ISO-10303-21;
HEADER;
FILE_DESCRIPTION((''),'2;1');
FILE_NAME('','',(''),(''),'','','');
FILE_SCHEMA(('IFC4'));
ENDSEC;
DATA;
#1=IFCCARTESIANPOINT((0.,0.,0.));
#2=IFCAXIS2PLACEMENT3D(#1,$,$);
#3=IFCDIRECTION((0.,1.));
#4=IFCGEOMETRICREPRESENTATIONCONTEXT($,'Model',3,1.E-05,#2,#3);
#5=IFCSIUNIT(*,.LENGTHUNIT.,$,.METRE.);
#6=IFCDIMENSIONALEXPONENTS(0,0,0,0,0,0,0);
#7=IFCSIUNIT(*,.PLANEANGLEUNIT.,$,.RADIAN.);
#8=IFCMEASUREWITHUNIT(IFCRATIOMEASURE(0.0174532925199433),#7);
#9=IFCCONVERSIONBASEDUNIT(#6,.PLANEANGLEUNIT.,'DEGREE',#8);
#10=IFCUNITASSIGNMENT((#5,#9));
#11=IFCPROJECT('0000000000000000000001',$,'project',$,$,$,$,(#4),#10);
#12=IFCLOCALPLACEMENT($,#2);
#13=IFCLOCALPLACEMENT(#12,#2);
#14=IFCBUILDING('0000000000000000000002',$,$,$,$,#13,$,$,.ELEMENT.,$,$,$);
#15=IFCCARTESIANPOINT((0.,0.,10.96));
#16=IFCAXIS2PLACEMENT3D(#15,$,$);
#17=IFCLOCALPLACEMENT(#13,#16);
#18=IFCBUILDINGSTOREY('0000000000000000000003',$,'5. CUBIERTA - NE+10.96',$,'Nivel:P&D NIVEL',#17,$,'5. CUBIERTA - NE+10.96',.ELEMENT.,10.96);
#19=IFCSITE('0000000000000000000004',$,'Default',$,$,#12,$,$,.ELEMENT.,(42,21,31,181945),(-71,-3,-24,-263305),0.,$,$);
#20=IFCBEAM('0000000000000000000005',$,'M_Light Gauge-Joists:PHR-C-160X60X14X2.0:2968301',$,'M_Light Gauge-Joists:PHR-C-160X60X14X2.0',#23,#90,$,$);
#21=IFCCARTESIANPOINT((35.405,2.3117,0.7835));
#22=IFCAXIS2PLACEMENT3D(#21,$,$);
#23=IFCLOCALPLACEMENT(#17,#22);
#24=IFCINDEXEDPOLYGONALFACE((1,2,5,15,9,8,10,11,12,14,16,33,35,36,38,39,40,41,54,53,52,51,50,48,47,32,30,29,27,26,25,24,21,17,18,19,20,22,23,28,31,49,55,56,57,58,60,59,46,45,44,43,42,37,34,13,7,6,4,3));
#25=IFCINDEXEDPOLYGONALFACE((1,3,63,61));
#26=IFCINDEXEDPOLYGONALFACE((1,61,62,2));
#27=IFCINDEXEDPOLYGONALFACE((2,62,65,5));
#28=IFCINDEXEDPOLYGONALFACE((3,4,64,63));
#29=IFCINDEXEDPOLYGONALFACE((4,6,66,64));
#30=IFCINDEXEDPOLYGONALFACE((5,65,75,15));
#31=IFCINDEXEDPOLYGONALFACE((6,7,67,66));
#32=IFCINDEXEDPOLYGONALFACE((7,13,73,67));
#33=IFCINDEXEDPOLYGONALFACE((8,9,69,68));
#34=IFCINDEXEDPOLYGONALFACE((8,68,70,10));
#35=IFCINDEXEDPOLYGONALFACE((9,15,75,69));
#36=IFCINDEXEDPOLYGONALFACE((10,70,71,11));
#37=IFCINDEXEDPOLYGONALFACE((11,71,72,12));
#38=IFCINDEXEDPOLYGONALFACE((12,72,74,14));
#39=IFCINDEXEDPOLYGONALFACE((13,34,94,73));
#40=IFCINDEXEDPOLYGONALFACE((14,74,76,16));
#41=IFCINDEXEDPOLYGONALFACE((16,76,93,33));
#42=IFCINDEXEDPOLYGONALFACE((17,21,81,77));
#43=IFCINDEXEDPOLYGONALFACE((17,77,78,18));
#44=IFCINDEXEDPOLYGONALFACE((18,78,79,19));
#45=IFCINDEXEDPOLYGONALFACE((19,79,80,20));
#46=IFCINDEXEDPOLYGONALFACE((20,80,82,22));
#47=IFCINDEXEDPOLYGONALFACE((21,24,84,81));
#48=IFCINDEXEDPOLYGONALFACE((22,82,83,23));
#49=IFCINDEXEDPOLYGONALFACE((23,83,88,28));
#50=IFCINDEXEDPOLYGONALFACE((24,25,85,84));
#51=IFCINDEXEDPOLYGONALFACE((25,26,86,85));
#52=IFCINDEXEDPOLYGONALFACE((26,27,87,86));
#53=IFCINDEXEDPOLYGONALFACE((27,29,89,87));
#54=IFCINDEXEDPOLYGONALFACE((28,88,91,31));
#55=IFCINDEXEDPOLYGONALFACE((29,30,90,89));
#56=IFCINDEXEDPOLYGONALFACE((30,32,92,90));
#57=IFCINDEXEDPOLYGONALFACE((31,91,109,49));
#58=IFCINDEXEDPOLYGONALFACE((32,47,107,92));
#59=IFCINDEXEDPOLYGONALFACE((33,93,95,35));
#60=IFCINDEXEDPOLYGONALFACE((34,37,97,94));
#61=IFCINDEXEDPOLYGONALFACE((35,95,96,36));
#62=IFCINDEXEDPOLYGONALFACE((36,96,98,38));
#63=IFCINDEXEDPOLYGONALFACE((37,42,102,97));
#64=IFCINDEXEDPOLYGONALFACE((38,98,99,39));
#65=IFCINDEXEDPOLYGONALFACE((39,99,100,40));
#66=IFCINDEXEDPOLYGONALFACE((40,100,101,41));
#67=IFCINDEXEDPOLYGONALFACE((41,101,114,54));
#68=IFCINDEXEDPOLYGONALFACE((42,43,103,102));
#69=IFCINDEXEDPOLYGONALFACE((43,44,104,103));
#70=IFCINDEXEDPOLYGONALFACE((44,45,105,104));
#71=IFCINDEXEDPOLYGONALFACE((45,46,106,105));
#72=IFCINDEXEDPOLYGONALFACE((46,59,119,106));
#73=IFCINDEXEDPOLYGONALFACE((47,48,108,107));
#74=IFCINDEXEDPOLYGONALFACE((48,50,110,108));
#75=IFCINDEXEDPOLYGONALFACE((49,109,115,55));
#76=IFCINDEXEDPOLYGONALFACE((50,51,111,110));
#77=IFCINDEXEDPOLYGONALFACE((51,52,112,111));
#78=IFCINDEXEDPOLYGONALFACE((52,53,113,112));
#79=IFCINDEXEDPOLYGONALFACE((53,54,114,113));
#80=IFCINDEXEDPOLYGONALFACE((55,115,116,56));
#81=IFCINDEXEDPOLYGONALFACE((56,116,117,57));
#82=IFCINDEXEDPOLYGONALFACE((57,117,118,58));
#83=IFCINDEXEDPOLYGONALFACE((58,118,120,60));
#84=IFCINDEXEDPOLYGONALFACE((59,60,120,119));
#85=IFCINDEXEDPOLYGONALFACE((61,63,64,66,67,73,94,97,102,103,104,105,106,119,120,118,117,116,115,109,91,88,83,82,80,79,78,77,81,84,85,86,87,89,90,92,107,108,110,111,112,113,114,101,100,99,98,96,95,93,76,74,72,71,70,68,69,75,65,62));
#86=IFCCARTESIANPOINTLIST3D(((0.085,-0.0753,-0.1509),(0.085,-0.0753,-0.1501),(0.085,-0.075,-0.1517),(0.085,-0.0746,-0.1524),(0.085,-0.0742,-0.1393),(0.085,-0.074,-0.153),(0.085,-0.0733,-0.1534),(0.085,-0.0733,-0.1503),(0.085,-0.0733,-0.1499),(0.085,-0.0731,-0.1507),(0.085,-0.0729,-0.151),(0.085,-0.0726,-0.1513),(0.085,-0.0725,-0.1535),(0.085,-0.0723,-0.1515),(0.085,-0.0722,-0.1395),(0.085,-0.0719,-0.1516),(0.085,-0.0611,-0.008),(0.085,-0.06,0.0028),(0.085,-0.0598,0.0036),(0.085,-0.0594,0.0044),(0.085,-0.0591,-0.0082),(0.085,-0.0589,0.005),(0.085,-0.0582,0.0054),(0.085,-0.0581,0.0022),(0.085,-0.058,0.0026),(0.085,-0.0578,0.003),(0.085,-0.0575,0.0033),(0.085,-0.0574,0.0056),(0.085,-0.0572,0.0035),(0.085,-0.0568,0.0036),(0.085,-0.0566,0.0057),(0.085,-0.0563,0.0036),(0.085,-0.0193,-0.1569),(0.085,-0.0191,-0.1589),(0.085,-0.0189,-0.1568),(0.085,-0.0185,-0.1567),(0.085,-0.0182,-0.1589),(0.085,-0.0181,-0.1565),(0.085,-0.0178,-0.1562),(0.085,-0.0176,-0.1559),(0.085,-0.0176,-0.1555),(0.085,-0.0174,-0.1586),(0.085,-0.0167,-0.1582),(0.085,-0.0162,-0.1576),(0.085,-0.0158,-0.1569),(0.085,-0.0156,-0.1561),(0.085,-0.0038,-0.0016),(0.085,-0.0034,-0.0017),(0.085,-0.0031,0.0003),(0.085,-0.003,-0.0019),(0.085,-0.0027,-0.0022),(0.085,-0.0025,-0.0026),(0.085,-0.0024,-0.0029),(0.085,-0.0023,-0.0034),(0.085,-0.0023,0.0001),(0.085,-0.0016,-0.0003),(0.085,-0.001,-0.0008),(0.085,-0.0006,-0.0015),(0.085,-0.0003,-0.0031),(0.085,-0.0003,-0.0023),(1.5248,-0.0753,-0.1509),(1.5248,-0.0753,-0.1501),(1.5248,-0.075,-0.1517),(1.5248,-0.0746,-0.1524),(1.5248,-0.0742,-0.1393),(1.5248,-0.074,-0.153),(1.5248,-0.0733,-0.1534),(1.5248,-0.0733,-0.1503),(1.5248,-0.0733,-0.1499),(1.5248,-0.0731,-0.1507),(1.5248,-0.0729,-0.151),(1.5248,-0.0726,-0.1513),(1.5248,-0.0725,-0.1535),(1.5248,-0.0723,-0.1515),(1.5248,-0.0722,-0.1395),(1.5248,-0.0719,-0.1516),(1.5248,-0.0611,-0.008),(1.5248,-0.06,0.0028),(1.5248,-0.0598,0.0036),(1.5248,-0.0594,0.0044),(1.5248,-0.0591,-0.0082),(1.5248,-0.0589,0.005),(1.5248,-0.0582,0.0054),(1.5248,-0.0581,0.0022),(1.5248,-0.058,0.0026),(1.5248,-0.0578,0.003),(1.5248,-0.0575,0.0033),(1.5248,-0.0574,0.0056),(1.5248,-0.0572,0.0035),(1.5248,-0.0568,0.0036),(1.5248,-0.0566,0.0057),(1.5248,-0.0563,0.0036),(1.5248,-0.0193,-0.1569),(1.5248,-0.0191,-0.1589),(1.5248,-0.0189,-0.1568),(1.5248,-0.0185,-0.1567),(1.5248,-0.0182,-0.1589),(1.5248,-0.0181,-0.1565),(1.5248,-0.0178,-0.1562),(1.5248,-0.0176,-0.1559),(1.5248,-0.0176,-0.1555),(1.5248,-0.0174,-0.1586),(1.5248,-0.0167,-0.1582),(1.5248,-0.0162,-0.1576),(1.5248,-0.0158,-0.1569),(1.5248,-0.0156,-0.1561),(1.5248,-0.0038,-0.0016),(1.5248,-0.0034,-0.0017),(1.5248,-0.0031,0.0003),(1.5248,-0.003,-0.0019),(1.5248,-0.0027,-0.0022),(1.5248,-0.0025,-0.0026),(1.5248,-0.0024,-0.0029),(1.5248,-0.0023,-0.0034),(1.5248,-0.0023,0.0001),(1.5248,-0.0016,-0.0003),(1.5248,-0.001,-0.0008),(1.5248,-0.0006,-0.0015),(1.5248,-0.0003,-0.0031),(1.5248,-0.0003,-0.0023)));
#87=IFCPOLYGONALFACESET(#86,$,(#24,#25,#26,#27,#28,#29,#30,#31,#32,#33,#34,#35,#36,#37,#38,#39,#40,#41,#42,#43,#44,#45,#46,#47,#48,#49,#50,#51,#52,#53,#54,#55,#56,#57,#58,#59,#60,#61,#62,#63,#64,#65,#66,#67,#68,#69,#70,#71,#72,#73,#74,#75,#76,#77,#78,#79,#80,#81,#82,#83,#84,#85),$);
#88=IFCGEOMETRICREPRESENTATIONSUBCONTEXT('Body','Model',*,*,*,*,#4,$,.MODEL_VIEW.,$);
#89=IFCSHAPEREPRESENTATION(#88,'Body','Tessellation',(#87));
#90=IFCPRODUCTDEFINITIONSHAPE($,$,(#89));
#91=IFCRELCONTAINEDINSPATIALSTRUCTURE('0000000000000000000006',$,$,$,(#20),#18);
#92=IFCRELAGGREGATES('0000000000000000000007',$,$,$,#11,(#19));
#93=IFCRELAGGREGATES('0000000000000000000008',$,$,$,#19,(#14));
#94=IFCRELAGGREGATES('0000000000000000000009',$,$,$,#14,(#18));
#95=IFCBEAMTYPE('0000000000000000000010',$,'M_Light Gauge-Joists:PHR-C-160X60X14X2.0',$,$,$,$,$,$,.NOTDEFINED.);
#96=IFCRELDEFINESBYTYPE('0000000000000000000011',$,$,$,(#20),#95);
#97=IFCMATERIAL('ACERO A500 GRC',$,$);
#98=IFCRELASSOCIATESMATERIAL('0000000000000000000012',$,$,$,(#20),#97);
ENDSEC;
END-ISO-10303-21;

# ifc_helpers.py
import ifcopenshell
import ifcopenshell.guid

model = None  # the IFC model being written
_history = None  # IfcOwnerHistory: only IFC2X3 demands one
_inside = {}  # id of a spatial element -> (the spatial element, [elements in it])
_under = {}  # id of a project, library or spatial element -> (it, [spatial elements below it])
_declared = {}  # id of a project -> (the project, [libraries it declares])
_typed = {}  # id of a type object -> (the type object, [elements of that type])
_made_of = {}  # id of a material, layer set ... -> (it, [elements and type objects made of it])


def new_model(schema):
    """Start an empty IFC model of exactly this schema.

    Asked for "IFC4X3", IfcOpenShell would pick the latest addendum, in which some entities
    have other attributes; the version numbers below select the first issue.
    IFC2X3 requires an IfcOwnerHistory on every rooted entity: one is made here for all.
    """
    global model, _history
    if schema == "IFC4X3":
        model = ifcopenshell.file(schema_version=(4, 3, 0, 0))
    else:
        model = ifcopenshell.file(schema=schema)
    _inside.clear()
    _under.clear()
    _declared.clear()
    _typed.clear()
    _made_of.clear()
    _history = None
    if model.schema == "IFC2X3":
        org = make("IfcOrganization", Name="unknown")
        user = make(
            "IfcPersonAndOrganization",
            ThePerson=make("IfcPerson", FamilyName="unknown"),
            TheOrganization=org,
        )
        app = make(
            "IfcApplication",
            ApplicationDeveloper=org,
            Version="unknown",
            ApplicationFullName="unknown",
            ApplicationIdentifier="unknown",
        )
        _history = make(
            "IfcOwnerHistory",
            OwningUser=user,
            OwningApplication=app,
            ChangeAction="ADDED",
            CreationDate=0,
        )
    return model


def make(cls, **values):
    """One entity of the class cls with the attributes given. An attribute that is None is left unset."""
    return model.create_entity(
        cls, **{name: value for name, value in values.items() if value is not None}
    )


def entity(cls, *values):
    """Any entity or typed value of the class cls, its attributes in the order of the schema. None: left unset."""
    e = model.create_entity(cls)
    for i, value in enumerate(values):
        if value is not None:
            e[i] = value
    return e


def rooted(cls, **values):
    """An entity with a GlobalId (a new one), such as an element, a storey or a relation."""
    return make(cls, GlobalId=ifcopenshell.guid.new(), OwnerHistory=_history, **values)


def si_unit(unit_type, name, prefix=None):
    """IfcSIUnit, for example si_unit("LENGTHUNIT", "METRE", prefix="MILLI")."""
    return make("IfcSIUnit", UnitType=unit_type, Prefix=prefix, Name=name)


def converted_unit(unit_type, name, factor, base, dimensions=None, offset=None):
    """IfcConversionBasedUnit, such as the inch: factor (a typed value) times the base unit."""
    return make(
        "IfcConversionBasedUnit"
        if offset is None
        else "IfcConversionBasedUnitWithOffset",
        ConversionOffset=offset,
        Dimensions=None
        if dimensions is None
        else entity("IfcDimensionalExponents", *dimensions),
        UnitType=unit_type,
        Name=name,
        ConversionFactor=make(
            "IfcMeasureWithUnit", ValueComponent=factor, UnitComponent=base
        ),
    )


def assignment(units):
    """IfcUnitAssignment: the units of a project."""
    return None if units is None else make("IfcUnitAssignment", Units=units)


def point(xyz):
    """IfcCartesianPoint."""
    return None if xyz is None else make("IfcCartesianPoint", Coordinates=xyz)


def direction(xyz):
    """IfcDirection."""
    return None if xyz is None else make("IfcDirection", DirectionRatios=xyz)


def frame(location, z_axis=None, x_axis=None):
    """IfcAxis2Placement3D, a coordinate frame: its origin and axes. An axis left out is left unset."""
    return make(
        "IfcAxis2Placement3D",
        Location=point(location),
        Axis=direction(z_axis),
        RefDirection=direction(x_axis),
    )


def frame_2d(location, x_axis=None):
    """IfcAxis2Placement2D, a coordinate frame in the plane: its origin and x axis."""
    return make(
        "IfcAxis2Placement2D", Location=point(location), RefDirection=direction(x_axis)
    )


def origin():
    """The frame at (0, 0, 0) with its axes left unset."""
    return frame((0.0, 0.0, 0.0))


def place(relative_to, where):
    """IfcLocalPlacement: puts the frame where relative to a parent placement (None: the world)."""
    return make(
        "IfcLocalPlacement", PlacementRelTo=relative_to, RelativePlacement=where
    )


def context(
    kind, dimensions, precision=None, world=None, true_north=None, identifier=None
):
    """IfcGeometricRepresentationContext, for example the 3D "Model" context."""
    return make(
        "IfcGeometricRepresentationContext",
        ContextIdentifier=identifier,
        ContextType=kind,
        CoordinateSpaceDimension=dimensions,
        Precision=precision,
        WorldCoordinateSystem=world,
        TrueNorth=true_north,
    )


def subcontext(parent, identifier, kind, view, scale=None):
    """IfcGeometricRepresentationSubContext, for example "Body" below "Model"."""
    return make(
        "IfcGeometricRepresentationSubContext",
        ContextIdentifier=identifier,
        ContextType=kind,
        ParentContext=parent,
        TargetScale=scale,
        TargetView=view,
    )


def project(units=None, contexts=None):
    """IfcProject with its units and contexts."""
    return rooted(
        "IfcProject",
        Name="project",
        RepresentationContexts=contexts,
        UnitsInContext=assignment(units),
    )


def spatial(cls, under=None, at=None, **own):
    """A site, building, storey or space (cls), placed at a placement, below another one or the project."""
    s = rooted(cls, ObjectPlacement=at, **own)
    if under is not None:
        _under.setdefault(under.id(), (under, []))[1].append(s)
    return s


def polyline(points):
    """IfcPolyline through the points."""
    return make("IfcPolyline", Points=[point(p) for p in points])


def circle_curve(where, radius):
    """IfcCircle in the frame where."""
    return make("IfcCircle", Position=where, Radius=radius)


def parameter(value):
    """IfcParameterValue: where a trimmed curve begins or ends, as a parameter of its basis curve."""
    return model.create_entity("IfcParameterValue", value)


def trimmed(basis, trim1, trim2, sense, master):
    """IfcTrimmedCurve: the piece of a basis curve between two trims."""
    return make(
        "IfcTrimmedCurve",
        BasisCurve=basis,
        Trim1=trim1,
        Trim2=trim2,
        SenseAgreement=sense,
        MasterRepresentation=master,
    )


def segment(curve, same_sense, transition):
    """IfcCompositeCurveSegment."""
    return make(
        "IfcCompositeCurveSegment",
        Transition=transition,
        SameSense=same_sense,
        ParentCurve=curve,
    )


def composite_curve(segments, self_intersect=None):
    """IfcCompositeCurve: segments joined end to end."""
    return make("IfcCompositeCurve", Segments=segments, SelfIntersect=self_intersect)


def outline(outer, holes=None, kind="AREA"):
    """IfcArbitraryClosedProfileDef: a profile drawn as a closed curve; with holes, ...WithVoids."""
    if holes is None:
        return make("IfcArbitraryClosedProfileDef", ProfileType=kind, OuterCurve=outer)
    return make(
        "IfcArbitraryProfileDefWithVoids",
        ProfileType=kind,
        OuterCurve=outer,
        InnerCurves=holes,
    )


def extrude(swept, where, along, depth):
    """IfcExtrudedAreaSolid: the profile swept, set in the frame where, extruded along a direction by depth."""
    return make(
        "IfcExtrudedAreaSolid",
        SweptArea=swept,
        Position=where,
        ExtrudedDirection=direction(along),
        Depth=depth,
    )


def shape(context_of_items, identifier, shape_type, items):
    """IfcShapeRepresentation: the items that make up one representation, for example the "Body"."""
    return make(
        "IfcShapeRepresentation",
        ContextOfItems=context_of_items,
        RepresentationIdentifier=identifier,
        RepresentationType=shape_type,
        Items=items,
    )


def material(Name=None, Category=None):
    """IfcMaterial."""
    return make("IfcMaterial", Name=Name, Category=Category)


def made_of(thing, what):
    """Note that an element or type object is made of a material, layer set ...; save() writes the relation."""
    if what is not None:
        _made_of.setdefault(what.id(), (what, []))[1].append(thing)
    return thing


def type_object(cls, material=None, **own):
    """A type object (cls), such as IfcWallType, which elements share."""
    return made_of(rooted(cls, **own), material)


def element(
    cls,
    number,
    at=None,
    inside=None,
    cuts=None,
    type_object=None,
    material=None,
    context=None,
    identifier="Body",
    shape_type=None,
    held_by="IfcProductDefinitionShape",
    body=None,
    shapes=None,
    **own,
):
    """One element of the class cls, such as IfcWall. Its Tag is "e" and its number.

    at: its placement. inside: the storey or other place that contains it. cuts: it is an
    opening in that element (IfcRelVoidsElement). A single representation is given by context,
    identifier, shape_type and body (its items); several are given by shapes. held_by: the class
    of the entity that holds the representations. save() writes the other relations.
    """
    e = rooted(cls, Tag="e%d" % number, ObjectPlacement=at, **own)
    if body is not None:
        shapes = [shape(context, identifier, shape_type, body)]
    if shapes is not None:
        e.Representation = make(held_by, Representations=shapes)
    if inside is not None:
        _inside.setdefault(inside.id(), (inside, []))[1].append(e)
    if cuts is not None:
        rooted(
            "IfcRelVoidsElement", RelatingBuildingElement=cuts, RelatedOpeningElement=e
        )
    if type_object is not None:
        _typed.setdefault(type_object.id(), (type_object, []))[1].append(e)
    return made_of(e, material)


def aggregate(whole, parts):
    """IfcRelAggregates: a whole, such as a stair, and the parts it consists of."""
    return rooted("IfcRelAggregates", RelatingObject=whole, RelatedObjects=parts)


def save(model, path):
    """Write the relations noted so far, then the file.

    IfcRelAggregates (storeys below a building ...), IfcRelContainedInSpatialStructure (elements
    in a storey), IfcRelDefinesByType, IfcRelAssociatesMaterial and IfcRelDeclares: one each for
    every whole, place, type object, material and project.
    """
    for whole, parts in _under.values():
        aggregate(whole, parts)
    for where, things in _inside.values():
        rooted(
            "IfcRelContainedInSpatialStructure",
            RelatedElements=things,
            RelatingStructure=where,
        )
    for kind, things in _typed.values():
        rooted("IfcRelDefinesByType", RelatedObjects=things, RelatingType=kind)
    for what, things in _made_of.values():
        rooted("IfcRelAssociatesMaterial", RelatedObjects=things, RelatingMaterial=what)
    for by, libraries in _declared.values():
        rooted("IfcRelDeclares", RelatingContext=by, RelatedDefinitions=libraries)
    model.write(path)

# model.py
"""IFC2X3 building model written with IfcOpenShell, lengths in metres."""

from ifc_helpers import new_model, entity, si_unit, converted_unit, direction, frame, frame_2d, origin, place, context, subcontext, project, spatial, polyline, circle_curve, parameter, trimmed, segment, composite_curve, outline, extrude, material, type_object, element, save


model = new_model("IFC2X3")

# Units and contexts
model_context = context("Model", 3, precision=1e-05, world=origin(), true_north=direction((0.0, 1.0)))
body_context = subcontext(model_context, "Body", "Model", "MODEL_VIEW")
ifc_project = project(units=[si_unit("LENGTHUNIT", "METRE"), converted_unit("PLANEANGLEUNIT", "DEGREE", entity("IfcRatioMeasure", 0.0174532925199433), si_unit("PLANEANGLEUNIT", "RADIAN"), dimensions=[0, 0, 0, 0, 0, 0, 0])], contexts=[model_context])

# Site, building, storey
site_placement = place(None, origin())
site = spatial("IfcSite", under=ifc_project, at=site_placement, Name="Default", CompositionType="ELEMENT", RefLatitude=(42, 21, 31, 181945), RefLongitude=(-71, -3, -24, -263305), RefElevation=0.0)
building_placement = place(site_placement, origin())
building = spatial("IfcBuilding", under=site, at=building_placement, CompositionType="ELEMENT")
storey_placement = place(building_placement, frame((0.0, 0.0, 10.96)))
storey = spatial("IfcBuildingStorey", under=building, at=storey_placement, Name="5. CUBIERTA - NE+10.96", ObjectType="Nivel:P&D NIVEL", LongName="5. CUBIERTA - NE+10.96", CompositionType="ELEMENT", Elevation=10.96)

# Beam
ifc_material_1 = material(Name="ACERO A500 GRC")
beam_type_1 = type_object("IfcBeamType", Name="M_Light Gauge-Joists:PHR-C-160X60X14X2.0", PredefinedType="NOTDEFINED")
beam_1_placement = place(storey_placement, frame((35.405, 2.3117, 0.7835)))
element("IfcBeam", 1, at=beam_1_placement, inside=storey, type_object=beam_type_1, material=ifc_material_1, Name="M_Light Gauge-Joists:PHR-C-160X60X14X2.0:2968301", ObjectType="M_Light Gauge-Joists:PHR-C-160X60X14X2.0", context=body_context, shape_type="SweptSolid", body=[
    extrude(outline(composite_curve([segment(polyline([(-0.0768, -0.0358), (0.0768, -0.0358)]), True, "CONTINUOUS"), segment(trimmed(circle_curve(frame_2d((0.0768, -0.0326), x_axis=(0.0, -1.0)), 0.0032), [parameter(0.0)], [parameter(90.0)], True, "PARAMETER"), True, "CONTINUOUS"), segment(polyline([(0.08, -0.0326), (0.08, 0.021)]), True, "CONTINUOUS"), segment(trimmed(circle_curve(frame_2d((0.0768, 0.021), x_axis=(1.0, 0.0)), 0.0032), [parameter(0.0)], [parameter(90.0)], True, "PARAMETER"), True, "CONTINUOUS"), segment(polyline([(0.0768, 0.0242), (0.066, 0.0242)]), True, "CONTINUOUS"), segment(polyline([(0.066, 0.0242), (0.066, 0.0222)]), True, "CONTINUOUS"), segment(polyline([(0.066, 0.0222), (0.0764, 0.0222)]), True, "CONTINUOUS"), segment(trimmed(circle_curve(frame_2d((0.0764, 0.0206), x_axis=(0.0, 1.0)), 0.0016), [parameter(270.0)], [parameter(0.0)], True, "PARAMETER"), False, "CONTINUOUS"), segment(polyline([(0.078, 0.0206), (0.078, -0.0322)]), True, "CONTINUOUS"), segment(trimmed(circle_curve(frame_2d((0.0764, -0.0322), x_axis=(1.0, 0.0)), 0.0016), [parameter(270.0)], [parameter(0.0)], True, "PARAMETER"), False, "CONTINUOUS"), segment(polyline([(0.0764, -0.0338), (-0.0764, -0.0338)]), True, "CONTINUOUS"), segment(trimmed(circle_curve(frame_2d((-0.0764, -0.0322), x_axis=(0.0, -1.0)), 0.0016), [parameter(270.0)], [parameter(0.0)], True, "PARAMETER"), False, "CONTINUOUS"), segment(polyline([(-0.078, -0.0322), (-0.078, 0.0206)]), True, "CONTINUOUS"), segment(trimmed(circle_curve(frame_2d((-0.0764, 0.0206), x_axis=(-1.0, 0.0)), 0.0016), [parameter(270.0)], [parameter(0.0)], True, "PARAMETER"), False, "CONTINUOUS"), segment(polyline([(-0.0764, 0.0222), (-0.066, 0.0222)]), True, "CONTINUOUS"), segment(polyline([(-0.066, 0.0222), (-0.066, 0.0242)]), True, "CONTINUOUS"), segment(polyline([(-0.066, 0.0242), (-0.0768, 0.0242)]), True, "CONTINUOUS"), segment(trimmed(circle_curve(frame_2d((-0.0768, 0.021), x_axis=(0.0, 1.0)), 0.0032), [parameter(0.0)], [parameter(90.0)], True, "PARAMETER"), True, "CONTINUOUS"), segment(polyline([(-0.08, 0.021), (-0.08, -0.0326)]), True, "CONTINUOUS"), segment(trimmed(circle_curve(frame_2d((-0.0768, -0.0326), x_axis=(-1.0, 0.0)), 0.0032), [parameter(0.0)], [parameter(90.0)], True, "PARAMETER"), True, "CONTINUOUS")], self_intersect=False)), frame((0.085, -0.0436, -0.076), z_axis=(1.0, 0.0, 0.0), x_axis=(0.0, 0.099504, 0.995037)), (0.0, 0.0, 1.0), 1.4398),
])

save(model, "model.ifc")
